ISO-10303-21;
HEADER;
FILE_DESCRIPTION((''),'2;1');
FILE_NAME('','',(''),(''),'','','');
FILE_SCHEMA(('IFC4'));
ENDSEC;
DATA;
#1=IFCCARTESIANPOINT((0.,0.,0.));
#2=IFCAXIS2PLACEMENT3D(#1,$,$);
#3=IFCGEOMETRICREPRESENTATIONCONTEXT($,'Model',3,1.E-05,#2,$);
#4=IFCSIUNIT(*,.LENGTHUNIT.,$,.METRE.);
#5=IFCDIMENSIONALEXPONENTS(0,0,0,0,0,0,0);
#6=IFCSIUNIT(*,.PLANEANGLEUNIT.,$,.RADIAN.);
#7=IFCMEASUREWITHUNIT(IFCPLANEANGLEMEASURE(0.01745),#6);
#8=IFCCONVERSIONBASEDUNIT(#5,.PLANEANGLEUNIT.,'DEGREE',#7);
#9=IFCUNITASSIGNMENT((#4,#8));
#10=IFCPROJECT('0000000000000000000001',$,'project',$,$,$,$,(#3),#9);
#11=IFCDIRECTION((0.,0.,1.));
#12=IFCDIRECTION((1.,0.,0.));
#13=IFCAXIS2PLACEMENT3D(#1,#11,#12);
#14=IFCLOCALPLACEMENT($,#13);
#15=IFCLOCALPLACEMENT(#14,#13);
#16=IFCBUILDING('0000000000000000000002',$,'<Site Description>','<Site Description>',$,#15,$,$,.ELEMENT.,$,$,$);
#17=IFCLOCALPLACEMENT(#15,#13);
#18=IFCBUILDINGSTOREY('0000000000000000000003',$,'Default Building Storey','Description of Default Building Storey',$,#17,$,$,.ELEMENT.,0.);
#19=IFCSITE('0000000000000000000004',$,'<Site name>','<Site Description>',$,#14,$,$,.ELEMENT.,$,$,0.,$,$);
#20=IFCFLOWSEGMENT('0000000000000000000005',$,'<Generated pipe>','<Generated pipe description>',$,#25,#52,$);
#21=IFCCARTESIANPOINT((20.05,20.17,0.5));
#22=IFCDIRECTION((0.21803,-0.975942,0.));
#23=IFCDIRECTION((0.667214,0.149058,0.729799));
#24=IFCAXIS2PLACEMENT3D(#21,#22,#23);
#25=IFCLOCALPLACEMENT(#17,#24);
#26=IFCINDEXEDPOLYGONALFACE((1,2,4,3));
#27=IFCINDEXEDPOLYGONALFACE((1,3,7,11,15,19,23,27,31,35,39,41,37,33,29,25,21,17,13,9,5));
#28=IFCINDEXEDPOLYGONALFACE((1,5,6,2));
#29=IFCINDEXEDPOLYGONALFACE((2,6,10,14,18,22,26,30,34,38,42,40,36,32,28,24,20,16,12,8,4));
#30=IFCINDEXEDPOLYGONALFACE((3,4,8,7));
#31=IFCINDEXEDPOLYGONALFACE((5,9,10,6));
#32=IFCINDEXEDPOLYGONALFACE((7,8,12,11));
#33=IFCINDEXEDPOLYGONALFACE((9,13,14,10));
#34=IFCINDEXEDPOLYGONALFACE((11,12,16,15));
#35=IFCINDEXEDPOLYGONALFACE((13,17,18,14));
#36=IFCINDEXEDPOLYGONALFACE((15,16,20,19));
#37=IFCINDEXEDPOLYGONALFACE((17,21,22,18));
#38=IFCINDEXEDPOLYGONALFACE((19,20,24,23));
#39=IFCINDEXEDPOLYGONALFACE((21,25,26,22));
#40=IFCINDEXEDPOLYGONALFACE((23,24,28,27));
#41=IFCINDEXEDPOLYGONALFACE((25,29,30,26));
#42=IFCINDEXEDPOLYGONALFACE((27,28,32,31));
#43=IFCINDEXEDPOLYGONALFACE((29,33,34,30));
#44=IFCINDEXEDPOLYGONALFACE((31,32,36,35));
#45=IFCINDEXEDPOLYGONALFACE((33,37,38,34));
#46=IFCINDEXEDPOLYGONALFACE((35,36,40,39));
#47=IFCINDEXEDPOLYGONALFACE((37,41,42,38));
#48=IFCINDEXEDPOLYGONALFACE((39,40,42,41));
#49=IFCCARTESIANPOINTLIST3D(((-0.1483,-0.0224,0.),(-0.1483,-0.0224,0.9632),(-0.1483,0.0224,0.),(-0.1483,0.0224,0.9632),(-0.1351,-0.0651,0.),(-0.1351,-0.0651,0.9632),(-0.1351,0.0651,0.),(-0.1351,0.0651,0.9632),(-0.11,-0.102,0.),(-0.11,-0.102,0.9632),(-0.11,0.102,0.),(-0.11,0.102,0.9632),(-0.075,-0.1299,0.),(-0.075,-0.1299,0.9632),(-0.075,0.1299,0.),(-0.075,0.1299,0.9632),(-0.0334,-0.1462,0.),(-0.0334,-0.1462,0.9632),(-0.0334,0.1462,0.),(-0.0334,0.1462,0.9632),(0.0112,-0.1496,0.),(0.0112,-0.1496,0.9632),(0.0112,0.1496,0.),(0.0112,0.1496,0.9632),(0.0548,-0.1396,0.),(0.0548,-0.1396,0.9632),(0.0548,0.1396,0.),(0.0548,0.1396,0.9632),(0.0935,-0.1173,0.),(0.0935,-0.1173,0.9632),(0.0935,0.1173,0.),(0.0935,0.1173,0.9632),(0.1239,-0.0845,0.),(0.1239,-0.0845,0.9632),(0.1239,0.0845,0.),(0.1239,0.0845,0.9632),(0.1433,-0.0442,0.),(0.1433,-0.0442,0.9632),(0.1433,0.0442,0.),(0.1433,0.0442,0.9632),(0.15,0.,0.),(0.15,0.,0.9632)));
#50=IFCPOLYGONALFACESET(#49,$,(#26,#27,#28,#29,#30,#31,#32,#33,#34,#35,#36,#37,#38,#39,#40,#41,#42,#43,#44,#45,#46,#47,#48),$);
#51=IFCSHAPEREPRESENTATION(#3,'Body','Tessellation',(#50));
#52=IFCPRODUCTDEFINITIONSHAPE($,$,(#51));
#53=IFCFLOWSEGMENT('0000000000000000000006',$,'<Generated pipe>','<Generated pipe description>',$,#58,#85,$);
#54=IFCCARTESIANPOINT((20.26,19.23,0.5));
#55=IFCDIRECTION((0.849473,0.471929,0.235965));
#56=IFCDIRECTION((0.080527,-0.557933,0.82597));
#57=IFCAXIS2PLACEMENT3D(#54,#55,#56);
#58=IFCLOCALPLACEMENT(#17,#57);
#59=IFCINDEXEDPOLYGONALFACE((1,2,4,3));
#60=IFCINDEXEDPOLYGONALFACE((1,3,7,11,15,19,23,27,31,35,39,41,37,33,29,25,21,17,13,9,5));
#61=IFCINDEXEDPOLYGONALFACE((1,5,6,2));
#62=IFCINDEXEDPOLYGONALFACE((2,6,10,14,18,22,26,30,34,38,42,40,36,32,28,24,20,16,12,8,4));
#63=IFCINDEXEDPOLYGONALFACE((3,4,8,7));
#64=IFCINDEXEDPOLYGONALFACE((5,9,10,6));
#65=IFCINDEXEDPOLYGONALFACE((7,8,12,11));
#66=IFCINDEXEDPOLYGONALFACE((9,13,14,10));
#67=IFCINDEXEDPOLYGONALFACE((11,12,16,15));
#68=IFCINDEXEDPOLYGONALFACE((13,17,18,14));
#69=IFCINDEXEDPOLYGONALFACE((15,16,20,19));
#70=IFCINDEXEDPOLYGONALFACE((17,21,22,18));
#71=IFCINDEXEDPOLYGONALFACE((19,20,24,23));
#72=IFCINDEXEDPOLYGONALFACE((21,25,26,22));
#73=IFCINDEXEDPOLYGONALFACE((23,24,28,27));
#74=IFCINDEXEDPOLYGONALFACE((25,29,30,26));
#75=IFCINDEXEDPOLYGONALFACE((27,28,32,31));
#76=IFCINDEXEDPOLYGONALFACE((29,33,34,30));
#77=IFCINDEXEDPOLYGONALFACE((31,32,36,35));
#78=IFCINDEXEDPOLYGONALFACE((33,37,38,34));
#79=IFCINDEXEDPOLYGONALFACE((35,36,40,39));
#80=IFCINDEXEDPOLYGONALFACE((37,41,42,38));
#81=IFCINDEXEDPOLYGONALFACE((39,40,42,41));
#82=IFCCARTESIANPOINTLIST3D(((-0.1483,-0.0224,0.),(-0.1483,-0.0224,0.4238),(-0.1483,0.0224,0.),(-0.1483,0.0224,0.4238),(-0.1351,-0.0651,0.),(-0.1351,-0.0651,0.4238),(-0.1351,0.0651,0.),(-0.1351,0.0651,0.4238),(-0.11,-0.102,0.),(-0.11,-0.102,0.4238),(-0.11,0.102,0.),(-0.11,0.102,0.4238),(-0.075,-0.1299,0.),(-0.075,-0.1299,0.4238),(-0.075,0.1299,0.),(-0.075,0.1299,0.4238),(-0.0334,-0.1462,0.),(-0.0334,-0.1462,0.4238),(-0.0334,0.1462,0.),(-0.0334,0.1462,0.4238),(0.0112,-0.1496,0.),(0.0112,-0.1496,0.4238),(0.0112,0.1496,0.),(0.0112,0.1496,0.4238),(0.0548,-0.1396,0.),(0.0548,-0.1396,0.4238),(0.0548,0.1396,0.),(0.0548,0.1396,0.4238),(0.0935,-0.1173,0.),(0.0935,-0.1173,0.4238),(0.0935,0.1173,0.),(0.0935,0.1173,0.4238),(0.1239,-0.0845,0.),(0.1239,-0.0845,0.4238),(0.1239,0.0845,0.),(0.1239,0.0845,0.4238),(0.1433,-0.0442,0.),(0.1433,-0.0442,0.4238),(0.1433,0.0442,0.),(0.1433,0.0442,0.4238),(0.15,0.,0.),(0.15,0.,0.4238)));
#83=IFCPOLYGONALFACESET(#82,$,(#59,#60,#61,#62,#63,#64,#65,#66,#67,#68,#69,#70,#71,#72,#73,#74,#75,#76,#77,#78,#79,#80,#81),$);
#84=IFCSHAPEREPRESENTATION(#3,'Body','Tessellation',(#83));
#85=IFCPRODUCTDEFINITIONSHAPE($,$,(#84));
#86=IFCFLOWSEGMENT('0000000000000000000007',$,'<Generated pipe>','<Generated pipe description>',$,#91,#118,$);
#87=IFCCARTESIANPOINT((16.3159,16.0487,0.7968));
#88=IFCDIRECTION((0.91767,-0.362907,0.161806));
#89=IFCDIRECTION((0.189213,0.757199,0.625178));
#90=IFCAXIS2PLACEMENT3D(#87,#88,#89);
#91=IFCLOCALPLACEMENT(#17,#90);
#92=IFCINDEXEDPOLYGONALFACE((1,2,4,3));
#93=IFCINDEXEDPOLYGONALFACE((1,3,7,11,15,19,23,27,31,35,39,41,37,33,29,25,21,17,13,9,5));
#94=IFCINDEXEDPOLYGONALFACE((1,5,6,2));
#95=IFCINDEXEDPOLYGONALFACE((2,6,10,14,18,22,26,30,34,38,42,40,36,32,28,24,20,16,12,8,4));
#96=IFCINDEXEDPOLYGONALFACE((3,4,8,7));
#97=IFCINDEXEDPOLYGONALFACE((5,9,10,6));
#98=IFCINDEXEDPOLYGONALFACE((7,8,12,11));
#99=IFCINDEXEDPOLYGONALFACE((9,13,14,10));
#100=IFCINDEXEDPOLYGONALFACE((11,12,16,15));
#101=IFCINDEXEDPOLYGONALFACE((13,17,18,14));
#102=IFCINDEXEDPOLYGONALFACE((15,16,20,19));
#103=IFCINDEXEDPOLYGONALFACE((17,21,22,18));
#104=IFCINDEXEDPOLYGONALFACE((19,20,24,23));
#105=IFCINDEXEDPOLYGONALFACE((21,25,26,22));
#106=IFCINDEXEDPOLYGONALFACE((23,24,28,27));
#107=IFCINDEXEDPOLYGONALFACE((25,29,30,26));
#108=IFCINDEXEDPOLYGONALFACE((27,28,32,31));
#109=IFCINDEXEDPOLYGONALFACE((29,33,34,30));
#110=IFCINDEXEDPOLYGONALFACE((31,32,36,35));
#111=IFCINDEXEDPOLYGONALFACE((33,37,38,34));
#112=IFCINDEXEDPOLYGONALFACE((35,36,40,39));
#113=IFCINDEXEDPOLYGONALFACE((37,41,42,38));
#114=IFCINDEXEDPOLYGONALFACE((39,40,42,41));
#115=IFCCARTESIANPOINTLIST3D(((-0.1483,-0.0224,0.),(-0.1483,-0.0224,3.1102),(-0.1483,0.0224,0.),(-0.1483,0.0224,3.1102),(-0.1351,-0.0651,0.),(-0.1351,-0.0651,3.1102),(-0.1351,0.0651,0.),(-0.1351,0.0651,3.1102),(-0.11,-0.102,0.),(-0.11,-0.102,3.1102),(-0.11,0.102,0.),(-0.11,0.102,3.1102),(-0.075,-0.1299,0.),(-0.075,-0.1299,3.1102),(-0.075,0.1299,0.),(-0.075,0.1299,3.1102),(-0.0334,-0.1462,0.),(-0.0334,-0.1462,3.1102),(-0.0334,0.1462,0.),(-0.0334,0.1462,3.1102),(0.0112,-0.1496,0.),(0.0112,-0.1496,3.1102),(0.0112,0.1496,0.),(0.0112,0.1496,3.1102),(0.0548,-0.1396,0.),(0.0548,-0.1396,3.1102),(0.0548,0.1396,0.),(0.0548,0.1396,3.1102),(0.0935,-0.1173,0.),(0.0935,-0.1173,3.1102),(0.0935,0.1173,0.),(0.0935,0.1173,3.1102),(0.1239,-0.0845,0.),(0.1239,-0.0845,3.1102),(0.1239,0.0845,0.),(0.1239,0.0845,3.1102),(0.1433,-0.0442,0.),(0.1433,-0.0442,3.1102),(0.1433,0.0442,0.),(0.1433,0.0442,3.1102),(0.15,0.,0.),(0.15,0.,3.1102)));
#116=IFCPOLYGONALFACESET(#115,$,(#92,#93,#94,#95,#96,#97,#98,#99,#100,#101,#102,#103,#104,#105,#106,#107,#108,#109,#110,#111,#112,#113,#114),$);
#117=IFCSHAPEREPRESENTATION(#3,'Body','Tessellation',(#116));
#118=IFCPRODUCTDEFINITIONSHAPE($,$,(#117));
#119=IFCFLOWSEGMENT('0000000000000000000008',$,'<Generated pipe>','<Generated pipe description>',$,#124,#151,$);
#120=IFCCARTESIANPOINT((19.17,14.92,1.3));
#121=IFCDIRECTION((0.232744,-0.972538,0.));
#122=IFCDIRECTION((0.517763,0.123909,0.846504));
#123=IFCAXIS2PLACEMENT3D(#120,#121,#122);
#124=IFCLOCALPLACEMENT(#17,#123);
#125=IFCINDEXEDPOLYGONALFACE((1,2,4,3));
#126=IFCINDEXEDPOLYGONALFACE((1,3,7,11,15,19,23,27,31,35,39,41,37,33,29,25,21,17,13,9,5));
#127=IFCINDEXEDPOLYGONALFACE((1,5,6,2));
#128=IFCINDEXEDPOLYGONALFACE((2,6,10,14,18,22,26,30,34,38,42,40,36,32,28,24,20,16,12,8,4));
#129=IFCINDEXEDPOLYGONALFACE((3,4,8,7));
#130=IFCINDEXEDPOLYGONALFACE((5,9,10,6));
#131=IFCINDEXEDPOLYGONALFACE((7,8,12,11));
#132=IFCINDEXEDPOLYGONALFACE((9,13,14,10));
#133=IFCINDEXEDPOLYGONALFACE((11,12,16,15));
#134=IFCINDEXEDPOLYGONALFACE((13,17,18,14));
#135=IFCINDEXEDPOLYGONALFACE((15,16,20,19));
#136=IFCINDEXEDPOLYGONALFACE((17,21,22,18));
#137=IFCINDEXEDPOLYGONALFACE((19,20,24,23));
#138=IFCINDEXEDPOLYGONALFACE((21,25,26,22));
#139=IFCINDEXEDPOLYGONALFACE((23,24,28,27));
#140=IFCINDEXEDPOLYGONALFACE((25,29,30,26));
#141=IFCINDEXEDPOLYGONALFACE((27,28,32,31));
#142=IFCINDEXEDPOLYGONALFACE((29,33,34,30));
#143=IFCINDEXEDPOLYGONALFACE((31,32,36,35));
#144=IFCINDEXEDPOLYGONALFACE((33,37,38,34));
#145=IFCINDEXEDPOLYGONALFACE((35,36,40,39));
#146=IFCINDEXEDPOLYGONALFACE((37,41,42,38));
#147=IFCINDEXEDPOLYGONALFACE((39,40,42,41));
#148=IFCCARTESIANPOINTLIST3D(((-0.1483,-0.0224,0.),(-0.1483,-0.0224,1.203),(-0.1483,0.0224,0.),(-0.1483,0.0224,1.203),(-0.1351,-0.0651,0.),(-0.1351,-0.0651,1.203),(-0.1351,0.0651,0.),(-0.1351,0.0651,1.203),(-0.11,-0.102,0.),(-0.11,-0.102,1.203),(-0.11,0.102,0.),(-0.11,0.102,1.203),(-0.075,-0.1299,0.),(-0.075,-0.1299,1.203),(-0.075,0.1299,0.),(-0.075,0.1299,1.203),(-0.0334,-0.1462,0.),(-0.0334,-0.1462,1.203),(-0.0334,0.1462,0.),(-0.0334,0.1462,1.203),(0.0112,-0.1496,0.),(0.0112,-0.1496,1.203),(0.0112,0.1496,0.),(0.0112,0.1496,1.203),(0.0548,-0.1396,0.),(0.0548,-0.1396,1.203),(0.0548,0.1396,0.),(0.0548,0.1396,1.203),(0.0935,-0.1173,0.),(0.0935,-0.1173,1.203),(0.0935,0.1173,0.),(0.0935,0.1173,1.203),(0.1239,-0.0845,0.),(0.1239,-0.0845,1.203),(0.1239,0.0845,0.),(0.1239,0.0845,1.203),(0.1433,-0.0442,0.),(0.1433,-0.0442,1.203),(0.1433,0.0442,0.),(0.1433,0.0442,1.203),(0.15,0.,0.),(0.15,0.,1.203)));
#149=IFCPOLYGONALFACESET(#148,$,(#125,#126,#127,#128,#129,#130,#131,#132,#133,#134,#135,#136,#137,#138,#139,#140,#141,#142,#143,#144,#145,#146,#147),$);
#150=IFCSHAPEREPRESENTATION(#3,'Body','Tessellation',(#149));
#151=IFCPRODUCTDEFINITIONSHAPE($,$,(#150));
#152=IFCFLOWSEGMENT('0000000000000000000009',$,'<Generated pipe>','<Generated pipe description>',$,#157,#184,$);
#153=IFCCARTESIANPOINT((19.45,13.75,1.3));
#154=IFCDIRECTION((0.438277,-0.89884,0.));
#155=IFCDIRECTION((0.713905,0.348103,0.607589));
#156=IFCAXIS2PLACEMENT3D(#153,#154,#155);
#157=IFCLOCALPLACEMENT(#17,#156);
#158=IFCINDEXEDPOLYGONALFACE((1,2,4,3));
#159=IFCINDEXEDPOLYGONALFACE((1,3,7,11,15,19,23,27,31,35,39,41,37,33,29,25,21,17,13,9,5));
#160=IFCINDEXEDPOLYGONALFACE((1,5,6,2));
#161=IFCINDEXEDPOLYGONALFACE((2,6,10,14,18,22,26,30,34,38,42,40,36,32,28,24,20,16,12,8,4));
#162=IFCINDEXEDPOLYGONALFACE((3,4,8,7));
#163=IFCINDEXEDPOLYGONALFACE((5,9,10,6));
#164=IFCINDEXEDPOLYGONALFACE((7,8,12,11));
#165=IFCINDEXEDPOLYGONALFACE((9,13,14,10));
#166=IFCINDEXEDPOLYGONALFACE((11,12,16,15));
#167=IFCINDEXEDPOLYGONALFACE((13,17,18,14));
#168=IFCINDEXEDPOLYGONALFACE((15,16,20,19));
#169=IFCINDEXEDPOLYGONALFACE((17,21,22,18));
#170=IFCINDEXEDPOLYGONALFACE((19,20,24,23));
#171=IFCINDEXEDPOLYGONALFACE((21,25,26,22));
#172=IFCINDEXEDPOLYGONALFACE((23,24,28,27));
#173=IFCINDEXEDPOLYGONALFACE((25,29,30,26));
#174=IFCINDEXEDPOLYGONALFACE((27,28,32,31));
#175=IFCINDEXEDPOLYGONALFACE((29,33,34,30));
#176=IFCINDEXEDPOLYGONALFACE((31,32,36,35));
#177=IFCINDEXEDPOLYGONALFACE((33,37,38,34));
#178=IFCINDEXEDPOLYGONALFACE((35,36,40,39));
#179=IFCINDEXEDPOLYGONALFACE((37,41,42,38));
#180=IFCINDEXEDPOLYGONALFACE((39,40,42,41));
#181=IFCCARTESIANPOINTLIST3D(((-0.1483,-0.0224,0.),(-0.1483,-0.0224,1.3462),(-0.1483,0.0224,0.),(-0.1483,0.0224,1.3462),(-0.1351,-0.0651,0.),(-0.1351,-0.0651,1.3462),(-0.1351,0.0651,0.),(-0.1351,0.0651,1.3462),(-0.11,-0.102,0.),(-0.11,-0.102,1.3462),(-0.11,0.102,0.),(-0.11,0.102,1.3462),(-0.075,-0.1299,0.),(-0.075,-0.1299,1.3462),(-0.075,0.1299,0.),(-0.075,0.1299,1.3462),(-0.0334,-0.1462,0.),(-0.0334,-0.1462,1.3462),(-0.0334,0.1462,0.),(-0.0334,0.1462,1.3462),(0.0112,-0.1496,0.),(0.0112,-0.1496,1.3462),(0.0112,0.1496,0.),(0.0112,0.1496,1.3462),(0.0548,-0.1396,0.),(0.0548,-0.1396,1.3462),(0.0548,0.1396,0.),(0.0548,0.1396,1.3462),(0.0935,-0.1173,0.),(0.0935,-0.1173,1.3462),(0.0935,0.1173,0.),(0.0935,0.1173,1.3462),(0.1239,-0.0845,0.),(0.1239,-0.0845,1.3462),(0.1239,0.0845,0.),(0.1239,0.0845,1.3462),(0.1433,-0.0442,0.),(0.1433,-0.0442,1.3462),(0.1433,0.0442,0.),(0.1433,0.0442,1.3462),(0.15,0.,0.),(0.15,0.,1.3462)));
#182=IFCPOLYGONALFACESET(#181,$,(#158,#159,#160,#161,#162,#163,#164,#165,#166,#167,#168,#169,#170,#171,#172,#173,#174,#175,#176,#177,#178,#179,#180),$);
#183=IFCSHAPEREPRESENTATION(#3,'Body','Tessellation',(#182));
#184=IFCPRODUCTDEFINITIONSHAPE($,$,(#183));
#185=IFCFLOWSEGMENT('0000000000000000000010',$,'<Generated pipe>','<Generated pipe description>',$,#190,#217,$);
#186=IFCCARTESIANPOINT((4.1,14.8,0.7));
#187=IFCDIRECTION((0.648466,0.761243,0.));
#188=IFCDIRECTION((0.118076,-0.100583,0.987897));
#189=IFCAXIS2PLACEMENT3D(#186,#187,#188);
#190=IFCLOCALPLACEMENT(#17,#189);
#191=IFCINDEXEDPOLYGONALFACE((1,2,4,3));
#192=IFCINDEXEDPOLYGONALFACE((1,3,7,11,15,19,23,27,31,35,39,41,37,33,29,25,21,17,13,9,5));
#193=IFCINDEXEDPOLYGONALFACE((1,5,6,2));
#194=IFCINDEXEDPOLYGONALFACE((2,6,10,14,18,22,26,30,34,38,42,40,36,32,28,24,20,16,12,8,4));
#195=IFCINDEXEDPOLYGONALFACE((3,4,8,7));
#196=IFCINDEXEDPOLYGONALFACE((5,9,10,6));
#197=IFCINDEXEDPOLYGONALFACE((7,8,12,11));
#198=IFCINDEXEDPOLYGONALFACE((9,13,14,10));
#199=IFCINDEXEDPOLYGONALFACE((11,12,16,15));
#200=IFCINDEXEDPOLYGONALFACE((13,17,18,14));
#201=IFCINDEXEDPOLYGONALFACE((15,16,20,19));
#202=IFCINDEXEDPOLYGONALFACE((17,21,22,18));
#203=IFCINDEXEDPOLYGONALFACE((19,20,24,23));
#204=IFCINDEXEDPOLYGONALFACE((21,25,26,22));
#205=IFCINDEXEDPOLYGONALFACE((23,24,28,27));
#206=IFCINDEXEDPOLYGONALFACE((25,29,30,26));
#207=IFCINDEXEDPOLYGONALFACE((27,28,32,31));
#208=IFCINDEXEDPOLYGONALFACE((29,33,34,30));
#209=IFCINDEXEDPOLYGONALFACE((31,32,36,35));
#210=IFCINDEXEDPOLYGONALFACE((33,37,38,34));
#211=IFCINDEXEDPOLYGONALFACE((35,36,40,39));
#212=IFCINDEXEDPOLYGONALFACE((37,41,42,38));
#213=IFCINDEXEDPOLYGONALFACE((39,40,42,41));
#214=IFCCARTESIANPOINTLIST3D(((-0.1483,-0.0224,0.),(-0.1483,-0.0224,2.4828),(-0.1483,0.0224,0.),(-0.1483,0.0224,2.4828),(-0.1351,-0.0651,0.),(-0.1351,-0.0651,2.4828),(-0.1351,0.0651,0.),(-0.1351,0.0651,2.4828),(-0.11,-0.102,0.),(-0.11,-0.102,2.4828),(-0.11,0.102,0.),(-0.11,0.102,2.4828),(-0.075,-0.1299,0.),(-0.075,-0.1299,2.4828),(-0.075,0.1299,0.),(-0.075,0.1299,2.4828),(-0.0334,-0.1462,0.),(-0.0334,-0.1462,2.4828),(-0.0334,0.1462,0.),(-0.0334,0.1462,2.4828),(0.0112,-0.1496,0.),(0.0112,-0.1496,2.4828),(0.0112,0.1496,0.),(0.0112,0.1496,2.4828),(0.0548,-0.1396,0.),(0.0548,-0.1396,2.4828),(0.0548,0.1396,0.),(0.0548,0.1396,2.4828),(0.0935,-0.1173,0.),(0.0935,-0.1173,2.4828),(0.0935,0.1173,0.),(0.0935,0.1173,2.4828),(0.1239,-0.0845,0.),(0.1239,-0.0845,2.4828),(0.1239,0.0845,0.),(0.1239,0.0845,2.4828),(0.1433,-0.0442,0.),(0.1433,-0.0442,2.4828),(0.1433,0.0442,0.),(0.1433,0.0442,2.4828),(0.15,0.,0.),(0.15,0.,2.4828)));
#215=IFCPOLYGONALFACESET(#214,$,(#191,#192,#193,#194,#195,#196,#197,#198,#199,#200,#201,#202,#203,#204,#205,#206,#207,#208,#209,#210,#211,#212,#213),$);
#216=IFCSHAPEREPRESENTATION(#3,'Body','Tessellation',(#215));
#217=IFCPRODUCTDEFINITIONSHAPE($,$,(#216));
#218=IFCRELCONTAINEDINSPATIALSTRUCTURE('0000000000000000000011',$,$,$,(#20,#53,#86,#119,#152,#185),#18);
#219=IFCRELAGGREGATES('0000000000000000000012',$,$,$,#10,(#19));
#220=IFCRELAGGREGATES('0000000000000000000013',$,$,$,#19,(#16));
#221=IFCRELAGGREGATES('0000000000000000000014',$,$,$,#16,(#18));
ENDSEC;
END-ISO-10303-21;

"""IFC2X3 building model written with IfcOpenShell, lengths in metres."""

from ifc_helpers import new_model, entity, si_unit, converted_unit, frame, origin, origin_with_axes, origin_2d_with_axis, place, context, project, spatial, circle, extrude, element, save


model = new_model("IFC2X3")

# Units and contexts
model_context = context("Model", 3, precision=1e-05, world=origin())
ifc_project = project(units=[si_unit("LENGTHUNIT", "METRE"), converted_unit("PLANEANGLEUNIT", "DEGREE", entity("IfcPlaneAngleMeasure", 0.01745), si_unit("PLANEANGLEUNIT", "RADIAN"), dimensions=[0, 0, 0, 0, 0, 0, 0])], contexts=[model_context])

# Site, building, storey
site_placement = place(None, origin_with_axes())
site = spatial("IfcSite", under=ifc_project, at=site_placement, Name="<Site name>", Description="<Site Description>", CompositionType="ELEMENT", RefElevation=0.0)
building_placement = place(site_placement, origin_with_axes())
building = spatial("IfcBuilding", under=site, at=building_placement, Name="<Site Description>", Description="<Site Description>", CompositionType="ELEMENT")
storey_placement = place(building_placement, origin_with_axes())
storey = spatial("IfcBuildingStorey", under=building, at=storey_placement, Name="Default Building Storey", Description="Description of Default Building Storey", CompositionType="ELEMENT", Elevation=0.0)

# Flow segments
flow_segment_1_placement = place(storey_placement, frame((20.05, 20.17, 0.5), z_axis=(0.21803, -0.975942, 0.0), x_axis=(0.667214, 0.149058, 0.729799)))
element("IfcFlowSegment", 1, at=flow_segment_1_placement, inside=storey, Name="<Generated pipe>", Description="<Generated pipe description>", context=model_context, shape_type="SweptSolid", body=[
    extrude(circle(Radius=0.15, at=origin_2d_with_axis()), origin_with_axes(), (0.0, 0.0, 1.0), 0.9632),
])
flow_segment_2_placement = place(storey_placement, frame((20.26, 19.23, 0.5), z_axis=(0.849473, 0.471929, 0.235965), x_axis=(0.080527, -0.557933, 0.82597)))
element("IfcFlowSegment", 2, at=flow_segment_2_placement, inside=storey, Name="<Generated pipe>", Description="<Generated pipe description>", context=model_context, shape_type="SweptSolid", body=[
    extrude(circle(Radius=0.15, at=origin_2d_with_axis()), origin_with_axes(), (0.0, 0.0, 1.0), 0.4238),
])
flow_segment_3_placement = place(storey_placement, frame((16.3159, 16.0487, 0.7968), z_axis=(0.91767, -0.362907, 0.161806), x_axis=(0.189213, 0.757199, 0.625178)))
element("IfcFlowSegment", 3, at=flow_segment_3_placement, inside=storey, Name="<Generated pipe>", Description="<Generated pipe description>", context=model_context, shape_type="SweptSolid", body=[
    extrude(circle(Radius=0.15, at=origin_2d_with_axis()), origin_with_axes(), (0.0, 0.0, 1.0), 3.1102),
])
flow_segment_4_placement = place(storey_placement, frame((19.17, 14.92, 1.3), z_axis=(0.232744, -0.972538, 0.0), x_axis=(0.517763, 0.123909, 0.846504)))
element("IfcFlowSegment", 4, at=flow_segment_4_placement, inside=storey, Name="<Generated pipe>", Description="<Generated pipe description>", context=model_context, shape_type="SweptSolid", body=[
    extrude(circle(Radius=0.15, at=origin_2d_with_axis()), origin_with_axes(), (0.0, 0.0, 1.0), 1.203),
])
flow_segment_5_placement = place(storey_placement, frame((19.45, 13.75, 1.3), z_axis=(0.438277, -0.89884, 0.0), x_axis=(0.713905, 0.348103, 0.607589)))
element("IfcFlowSegment", 5, at=flow_segment_5_placement, inside=storey, Name="<Generated pipe>", Description="<Generated pipe description>", context=model_context, shape_type="SweptSolid", body=[
    extrude(circle(Radius=0.15, at=origin_2d_with_axis()), origin_with_axes(), (0.0, 0.0, 1.0), 1.3462),
])
flow_segment_6_placement = place(storey_placement, frame((4.1, 14.8, 0.7), z_axis=(0.648466, 0.761243, 0.0), x_axis=(0.118076, -0.100583, 0.987897)))
element("IfcFlowSegment", 6, at=flow_segment_6_placement, inside=storey, Name="<Generated pipe>", Description="<Generated pipe description>", context=model_context, shape_type="SweptSolid", body=[
    extrude(circle(Radius=0.15, at=origin_2d_with_axis()), origin_with_axes(), (0.0, 0.0, 1.0), 2.4828),
])

save(model, "model.ifc")
